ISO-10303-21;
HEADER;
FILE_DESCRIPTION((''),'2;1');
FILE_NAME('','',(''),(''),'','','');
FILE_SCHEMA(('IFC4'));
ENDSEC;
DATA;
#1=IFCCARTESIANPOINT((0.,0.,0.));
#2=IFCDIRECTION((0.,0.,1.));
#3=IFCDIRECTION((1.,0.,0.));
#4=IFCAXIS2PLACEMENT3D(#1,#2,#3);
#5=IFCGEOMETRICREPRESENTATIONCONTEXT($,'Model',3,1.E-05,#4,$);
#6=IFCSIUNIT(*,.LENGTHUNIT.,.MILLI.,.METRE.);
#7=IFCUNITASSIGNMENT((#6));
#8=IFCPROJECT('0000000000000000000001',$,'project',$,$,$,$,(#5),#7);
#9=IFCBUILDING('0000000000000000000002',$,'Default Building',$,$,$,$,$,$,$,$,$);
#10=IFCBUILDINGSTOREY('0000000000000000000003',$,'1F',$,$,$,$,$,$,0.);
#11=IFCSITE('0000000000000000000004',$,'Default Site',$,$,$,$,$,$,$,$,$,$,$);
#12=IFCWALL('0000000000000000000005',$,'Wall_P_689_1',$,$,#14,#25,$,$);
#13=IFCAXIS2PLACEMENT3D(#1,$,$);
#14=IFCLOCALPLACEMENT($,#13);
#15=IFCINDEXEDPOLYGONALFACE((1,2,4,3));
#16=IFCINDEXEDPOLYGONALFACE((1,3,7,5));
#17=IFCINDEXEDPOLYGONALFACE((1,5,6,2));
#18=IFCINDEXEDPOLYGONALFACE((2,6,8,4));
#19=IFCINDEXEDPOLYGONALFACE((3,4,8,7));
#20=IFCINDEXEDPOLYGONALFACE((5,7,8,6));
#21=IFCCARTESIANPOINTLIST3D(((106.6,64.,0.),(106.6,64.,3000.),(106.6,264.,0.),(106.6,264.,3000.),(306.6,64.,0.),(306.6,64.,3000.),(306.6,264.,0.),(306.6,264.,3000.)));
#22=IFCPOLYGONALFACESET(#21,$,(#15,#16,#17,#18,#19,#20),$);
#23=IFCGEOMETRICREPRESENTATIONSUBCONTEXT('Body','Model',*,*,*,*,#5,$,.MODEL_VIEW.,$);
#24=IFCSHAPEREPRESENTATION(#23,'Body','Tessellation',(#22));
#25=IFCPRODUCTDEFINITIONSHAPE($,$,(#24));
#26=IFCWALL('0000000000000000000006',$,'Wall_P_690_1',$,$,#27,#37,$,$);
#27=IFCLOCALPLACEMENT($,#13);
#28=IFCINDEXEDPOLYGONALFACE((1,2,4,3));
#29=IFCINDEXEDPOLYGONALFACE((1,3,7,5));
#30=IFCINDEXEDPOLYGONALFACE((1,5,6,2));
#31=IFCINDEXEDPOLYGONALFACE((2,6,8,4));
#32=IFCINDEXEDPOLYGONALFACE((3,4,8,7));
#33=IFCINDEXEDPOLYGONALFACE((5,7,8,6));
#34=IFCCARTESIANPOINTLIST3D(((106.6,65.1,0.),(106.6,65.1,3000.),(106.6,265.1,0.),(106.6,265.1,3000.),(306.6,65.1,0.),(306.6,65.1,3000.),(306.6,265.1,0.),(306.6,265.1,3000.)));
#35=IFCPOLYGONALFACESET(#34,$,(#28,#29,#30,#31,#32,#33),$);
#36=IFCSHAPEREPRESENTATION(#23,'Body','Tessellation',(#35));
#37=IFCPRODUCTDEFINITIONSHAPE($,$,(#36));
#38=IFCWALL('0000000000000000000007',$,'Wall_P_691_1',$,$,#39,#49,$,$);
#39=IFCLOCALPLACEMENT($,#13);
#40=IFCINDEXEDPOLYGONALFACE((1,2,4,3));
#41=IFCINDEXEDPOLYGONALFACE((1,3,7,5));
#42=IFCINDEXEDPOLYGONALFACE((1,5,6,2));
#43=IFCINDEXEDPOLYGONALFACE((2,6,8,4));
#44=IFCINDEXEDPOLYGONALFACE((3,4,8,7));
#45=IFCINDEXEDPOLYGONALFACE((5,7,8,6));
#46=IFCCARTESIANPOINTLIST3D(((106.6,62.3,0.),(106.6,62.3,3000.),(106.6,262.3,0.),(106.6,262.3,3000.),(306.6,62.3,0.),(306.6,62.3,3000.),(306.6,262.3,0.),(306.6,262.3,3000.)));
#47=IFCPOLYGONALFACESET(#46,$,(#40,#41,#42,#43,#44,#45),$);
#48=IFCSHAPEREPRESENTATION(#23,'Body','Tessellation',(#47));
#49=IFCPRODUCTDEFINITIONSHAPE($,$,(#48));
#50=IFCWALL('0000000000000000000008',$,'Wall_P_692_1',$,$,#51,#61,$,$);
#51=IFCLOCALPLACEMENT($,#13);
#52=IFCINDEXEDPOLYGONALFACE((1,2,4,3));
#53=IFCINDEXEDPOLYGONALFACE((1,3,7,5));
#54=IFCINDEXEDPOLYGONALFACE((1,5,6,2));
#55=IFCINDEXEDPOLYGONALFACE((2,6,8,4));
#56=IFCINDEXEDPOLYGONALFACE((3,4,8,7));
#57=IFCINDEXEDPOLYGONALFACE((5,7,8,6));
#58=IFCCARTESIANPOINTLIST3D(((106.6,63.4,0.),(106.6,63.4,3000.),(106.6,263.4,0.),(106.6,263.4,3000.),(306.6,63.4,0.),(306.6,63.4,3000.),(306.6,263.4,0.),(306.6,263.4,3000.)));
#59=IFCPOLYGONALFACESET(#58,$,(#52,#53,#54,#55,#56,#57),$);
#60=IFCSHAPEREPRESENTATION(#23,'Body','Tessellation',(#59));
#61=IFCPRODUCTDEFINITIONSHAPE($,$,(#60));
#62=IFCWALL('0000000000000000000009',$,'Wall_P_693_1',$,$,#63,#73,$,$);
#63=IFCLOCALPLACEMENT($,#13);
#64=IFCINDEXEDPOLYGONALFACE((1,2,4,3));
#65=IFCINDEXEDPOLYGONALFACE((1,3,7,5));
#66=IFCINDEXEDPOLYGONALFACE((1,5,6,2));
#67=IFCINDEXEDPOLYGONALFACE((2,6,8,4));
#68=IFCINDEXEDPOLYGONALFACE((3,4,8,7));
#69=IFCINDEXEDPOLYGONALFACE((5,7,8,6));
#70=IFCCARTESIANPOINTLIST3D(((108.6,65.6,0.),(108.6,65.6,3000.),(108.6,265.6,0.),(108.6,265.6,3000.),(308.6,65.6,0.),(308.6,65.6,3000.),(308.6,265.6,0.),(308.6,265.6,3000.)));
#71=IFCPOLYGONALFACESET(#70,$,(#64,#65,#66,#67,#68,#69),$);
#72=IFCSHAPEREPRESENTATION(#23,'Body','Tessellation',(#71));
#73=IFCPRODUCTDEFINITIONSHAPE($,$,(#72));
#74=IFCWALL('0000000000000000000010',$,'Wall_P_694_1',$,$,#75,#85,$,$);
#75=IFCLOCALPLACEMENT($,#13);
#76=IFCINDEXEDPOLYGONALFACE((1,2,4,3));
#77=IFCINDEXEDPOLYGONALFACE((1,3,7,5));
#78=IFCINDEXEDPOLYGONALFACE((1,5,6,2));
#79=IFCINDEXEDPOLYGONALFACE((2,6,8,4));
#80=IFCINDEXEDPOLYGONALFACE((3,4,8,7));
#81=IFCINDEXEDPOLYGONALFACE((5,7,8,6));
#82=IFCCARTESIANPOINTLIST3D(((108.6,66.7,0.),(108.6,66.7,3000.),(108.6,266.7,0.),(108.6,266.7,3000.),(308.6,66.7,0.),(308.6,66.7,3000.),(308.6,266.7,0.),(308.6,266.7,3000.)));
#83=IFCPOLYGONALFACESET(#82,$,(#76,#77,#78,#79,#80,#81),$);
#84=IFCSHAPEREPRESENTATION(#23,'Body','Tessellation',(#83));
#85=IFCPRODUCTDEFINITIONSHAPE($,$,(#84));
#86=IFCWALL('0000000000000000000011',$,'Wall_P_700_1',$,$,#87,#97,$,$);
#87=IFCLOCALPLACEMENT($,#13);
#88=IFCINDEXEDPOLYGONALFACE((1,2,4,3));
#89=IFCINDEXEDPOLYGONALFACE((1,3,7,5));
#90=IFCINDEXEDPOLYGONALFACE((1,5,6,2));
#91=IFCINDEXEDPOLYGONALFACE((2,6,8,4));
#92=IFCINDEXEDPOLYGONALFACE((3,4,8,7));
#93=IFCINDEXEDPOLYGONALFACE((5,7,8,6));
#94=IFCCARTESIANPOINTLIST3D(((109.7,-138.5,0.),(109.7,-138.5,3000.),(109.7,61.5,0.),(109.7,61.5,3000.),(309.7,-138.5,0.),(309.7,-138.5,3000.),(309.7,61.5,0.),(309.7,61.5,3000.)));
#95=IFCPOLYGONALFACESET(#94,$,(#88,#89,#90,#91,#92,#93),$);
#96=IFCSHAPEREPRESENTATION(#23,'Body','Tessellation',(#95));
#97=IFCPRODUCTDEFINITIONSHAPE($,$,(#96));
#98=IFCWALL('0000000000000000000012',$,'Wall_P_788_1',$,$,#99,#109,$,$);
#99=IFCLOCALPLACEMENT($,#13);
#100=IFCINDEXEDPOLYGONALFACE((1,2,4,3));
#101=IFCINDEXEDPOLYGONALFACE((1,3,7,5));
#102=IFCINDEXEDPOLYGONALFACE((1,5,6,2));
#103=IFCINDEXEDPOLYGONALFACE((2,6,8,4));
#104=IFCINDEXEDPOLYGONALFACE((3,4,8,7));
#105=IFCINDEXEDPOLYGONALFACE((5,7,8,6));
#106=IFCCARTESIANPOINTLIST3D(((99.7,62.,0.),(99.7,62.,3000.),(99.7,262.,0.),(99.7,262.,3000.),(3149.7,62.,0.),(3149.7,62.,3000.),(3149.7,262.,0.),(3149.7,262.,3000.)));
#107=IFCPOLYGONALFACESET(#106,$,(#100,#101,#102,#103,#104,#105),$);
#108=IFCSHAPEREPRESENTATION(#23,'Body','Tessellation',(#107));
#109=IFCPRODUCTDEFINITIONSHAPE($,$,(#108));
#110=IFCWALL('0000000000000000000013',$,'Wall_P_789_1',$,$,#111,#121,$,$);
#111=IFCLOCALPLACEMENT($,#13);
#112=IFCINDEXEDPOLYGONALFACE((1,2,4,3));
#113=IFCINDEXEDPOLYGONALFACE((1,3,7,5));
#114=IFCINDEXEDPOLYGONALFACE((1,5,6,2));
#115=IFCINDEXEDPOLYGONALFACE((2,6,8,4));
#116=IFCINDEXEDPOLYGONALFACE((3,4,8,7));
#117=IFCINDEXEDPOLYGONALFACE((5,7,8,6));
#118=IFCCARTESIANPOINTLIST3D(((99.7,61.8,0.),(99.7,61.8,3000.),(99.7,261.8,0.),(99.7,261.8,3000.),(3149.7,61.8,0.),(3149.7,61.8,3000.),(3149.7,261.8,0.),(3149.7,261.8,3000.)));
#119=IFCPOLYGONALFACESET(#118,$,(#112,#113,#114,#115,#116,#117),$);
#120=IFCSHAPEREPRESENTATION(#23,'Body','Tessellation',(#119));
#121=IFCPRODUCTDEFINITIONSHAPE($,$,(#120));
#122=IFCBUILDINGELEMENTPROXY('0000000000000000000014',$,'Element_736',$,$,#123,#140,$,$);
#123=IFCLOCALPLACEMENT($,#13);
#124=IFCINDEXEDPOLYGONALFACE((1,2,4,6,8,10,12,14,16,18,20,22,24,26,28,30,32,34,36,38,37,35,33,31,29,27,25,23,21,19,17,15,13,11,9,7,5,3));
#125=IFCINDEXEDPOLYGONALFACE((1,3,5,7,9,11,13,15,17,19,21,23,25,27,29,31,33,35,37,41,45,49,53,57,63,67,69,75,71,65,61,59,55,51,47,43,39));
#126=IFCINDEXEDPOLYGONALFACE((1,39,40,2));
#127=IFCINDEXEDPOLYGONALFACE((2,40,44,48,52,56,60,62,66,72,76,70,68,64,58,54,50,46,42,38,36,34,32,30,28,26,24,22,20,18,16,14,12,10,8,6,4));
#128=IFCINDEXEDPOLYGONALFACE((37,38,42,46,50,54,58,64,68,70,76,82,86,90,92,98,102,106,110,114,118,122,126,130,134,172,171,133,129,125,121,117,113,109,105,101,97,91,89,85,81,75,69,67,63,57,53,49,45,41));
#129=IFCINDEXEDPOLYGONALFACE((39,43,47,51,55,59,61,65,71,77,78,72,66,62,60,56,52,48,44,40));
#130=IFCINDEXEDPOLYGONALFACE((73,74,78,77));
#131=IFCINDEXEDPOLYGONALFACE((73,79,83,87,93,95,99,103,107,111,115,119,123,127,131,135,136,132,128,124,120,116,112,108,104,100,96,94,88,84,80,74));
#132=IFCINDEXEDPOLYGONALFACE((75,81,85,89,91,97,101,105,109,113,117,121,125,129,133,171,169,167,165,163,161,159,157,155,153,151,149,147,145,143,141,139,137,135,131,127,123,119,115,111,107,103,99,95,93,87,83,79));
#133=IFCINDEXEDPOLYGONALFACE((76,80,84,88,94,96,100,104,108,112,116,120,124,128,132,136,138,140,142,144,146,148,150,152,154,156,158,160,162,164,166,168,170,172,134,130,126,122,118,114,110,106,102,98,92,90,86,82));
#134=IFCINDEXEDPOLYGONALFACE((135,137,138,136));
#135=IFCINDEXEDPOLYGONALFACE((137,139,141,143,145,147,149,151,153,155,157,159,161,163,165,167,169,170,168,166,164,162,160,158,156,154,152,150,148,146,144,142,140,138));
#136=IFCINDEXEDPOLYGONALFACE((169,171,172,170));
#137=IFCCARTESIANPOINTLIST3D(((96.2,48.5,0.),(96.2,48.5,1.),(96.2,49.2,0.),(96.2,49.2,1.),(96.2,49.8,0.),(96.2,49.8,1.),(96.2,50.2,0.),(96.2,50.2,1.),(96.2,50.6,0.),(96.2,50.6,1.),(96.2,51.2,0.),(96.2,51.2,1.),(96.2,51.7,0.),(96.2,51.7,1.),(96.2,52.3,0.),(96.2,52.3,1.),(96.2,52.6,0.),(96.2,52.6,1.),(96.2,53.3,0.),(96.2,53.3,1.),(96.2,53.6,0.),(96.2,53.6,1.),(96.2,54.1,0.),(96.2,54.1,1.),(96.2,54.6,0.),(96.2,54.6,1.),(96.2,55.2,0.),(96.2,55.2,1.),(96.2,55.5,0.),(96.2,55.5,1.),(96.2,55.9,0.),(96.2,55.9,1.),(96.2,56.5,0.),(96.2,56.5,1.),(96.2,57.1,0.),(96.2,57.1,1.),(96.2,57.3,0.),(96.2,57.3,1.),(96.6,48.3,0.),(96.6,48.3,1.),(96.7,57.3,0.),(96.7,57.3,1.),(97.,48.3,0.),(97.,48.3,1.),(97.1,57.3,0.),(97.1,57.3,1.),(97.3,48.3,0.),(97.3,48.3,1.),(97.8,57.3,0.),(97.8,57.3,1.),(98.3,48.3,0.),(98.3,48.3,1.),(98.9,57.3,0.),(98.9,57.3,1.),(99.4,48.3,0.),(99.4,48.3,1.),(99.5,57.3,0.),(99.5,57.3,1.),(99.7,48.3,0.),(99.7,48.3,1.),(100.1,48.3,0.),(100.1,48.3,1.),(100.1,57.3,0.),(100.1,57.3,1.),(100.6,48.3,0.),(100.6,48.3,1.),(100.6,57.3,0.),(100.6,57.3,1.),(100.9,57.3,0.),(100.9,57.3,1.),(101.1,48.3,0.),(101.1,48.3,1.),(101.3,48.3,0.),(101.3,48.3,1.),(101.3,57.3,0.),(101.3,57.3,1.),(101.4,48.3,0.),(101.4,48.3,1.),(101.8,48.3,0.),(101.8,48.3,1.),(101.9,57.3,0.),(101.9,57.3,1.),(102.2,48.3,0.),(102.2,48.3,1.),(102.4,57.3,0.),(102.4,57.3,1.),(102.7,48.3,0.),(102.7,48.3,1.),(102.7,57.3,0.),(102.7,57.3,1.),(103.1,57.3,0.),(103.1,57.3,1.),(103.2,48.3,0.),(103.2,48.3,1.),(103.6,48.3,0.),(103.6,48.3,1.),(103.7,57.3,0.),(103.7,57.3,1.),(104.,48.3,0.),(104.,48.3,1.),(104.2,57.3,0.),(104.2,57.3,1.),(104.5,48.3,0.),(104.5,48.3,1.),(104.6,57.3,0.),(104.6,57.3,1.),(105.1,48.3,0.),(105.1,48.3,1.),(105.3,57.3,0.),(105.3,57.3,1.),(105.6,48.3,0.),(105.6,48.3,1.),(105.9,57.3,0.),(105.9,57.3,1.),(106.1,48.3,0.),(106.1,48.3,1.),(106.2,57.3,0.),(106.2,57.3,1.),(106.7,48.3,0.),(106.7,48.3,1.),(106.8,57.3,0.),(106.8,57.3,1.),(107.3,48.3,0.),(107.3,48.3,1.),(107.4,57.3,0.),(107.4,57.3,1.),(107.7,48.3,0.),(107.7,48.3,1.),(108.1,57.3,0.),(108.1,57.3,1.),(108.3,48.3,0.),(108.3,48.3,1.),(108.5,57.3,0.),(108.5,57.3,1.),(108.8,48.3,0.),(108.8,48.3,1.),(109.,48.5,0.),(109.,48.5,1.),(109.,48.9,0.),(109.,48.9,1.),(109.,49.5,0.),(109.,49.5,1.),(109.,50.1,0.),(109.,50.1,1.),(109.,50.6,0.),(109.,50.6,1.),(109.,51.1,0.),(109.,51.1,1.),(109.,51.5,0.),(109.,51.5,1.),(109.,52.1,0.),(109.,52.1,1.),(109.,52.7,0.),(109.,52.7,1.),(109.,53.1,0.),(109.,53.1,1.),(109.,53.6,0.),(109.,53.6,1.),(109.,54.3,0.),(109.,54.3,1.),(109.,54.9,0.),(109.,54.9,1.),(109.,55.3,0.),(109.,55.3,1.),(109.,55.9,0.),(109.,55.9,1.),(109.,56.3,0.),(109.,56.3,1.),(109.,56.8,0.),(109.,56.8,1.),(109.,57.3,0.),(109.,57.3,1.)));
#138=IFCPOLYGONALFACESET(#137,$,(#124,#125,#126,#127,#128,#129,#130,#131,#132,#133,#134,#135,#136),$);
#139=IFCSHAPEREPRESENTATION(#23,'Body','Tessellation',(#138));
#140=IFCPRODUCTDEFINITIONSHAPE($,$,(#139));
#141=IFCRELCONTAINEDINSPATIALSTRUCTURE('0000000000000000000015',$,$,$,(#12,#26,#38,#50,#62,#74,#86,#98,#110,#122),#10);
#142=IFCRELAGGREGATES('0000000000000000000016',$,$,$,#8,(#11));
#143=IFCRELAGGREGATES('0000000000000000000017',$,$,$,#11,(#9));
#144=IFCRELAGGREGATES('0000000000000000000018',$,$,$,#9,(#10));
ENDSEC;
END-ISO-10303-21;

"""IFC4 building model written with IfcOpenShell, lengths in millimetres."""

from ifc_helpers import new_model, si_unit, frame, origin, origin_with_axes, place, context, subcontext, project, spatial, polyline, indexed_curve, outline, extrude, element, save


model = new_model("IFC4")

# Units and contexts
model_context = context("Model", 3, precision=1e-05, world=origin_with_axes())
body_context = subcontext(model_context, "Body", "Model", "MODEL_VIEW")
ifc_project = project(units=[si_unit("LENGTHUNIT", "METRE", prefix="MILLI")], contexts=[model_context])

# Site, building, storey
site = spatial("IfcSite", under=ifc_project, Name="Default Site")
building = spatial("IfcBuilding", under=site, Name="Default Building")
storey = spatial("IfcBuildingStorey", under=building, Name="1F", Elevation=0.0)

# Walls
wall_1_placement = place(None, frame((106.6, 64.0, 0.0), z_axis=(0.0, 0.0, 1.0), x_axis=(1.0, 0.0, 0.0)))
element("IfcWall", 1, at=wall_1_placement, inside=storey, Name="Wall_P_689_1", context=body_context, shape_type="SweptSolid", body=[
    extrude(outline(indexed_curve([(0.0, 0.0), (0.0, 200.0), (200.0, 200.0), (200.0, 0.0), (0.0, 0.0)], self_intersect=False)), origin_with_axes(), (0.0, 0.0, 1.0), 3000.0),
])
wall_2_placement = place(None, frame((106.6, 65.1, 0.0), z_axis=(0.0, 0.0, 1.0), x_axis=(1.0, 0.0, 0.0)))
element("IfcWall", 2, at=wall_2_placement, inside=storey, Name="Wall_P_690_1", context=body_context, shape_type="SweptSolid", body=[
    extrude(outline(indexed_curve([(0.0, 0.0), (0.0, 200.0), (200.0, 200.0), (200.0, 0.0), (0.0, 0.0)], self_intersect=False)), origin_with_axes(), (0.0, 0.0, 1.0), 3000.0),
])
wall_3_placement = place(None, frame((106.6, 62.3, 0.0), z_axis=(0.0, 0.0, 1.0), x_axis=(1.0, 0.0, 0.0)))
element("IfcWall", 3, at=wall_3_placement, inside=storey, Name="Wall_P_691_1", context=body_context, shape_type="SweptSolid", body=[
    extrude(outline(indexed_curve([(0.0, 0.0), (0.0, 200.0), (200.0, 200.0), (200.0, 0.0), (0.0, 0.0)], self_intersect=False)), origin_with_axes(), (0.0, 0.0, 1.0), 3000.0),
])
wall_4_placement = place(None, frame((106.6, 63.4, 0.0), z_axis=(0.0, 0.0, 1.0), x_axis=(1.0, 0.0, 0.0)))
element("IfcWall", 4, at=wall_4_placement, inside=storey, Name="Wall_P_692_1", context=body_context, shape_type="SweptSolid", body=[
    extrude(outline(indexed_curve([(0.0, 0.0), (0.0, 200.0), (200.0, 200.0), (200.0, 0.0), (0.0, 0.0)], self_intersect=False)), origin_with_axes(), (0.0, 0.0, 1.0), 3000.0),
])
wall_5_placement = place(None, frame((108.6, 65.6, 0.0), z_axis=(0.0, 0.0, 1.0), x_axis=(1.0, 0.0, 0.0)))
element("IfcWall", 5, at=wall_5_placement, inside=storey, Name="Wall_P_693_1", context=body_context, shape_type="SweptSolid", body=[
    extrude(outline(indexed_curve([(0.0, 0.0), (0.0, 200.0), (200.0, 200.0), (200.0, 0.0), (0.0, 0.0)], self_intersect=False)), origin_with_axes(), (0.0, 0.0, 1.0), 3000.0),
])
wall_6_placement = place(None, frame((108.6, 66.7, 0.0), z_axis=(0.0, 0.0, 1.0), x_axis=(1.0, 0.0, 0.0)))
element("IfcWall", 6, at=wall_6_placement, inside=storey, Name="Wall_P_694_1", context=body_context, shape_type="SweptSolid", body=[
    extrude(outline(indexed_curve([(0.0, 0.0), (0.0, 200.0), (200.0, 200.0), (200.0, 0.0), (0.0, 0.0)], self_intersect=False)), origin_with_axes(), (0.0, 0.0, 1.0), 3000.0),
])
wall_7_placement = place(None, frame((109.7, 61.5, 0.0), z_axis=(0.0, 0.0, 1.0), x_axis=(0.0, -1.0, 0.0)))
element("IfcWall", 7, at=wall_7_placement, inside=storey, Name="Wall_P_700_1", context=body_context, shape_type="SweptSolid", body=[
    extrude(outline(indexed_curve([(0.0, 0.0), (0.0, 200.0), (200.0, 200.0), (200.0, 0.0), (0.0, 0.0)], self_intersect=False)), origin_with_axes(), (0.0, 0.0, 1.0), 3000.0),
])
for number, where, z_axis, x_axis, name in (
    (8, (99.7, 62.0, 0.0), (0.0, 0.0, 1.0), (1.0, 0.0, 0.0), "Wall_P_788_1"),
    (9, (99.7, 61.8, 0.0), (0.0, 0.0, 1.0), (1.0, 0.0, 0.0), "Wall_P_789_1"),
):
    element("IfcWall", number, at=place(None, frame(where, z_axis=z_axis, x_axis=x_axis)), inside=storey, Name=name, context=body_context, shape_type="SweptSolid", body=[
        extrude(outline(indexed_curve([(0.0, 0.0), (0.0, 200.0), (3050.0, 200.0), (3050.0, 0.0), (0.0, 0.0)], self_intersect=False)), origin_with_axes(), (0.0, 0.0, 1.0), 3000.0),
    ])

# Building element proxy
proxy_1_placement = place(None, frame((102.6, 52.8, 0.0), z_axis=(0.0, 0.0, 1.0), x_axis=(1.0, 0.0, 0.0)))
element("IfcBuildingElementProxy", 10, at=proxy_1_placement, inside=storey, Name="Element_736", context=body_context, shape_type="SweptSolid", body=[
    extrude(outline(polyline([(-6.4, 4.5), (-5.9, 4.5), (-5.5, 4.5), (-4.7, 4.5), (-3.6, 4.5), (-3.1, 4.5), (-2.4, 4.5), (-2.0, 4.5), (-1.6, 4.5), (-1.3, 4.5), (-1.3, 4.5), (-0.7, 4.5), (-0.2, 4.5), (0.1, 4.5), (0.5, 4.5), (1.1, 4.5), (1.7, 4.5), (2.1, 4.5), (2.7, 4.5), (3.3, 4.5), (3.6, 4.5), (4.2, 4.5), (4.9, 4.5), (5.5, 4.5), (5.9, 4.5), (6.4, 4.5), (6.4, 4.0), (6.4, 3.5), (6.4, 3.1), (6.4, 2.5), (6.4, 2.1), (6.4, 1.5), (6.4, 0.8), (6.4, 0.3), (6.4, -0.1), (6.4, -0.7), (6.4, -1.3), (6.4, -1.7), (6.4, -2.2), (6.4, -2.7), (6.4, -3.3), (6.4, -3.9), (6.4, -4.3), (6.2, -4.5), (5.7, -4.5), (5.1, -4.5), (4.8, -4.5), (4.2, -4.5), (3.5, -4.5), (3.0, -4.5), (2.5, -4.5), (2.0, -4.5), (1.4, -4.5), (1.1, -4.5), (0.6, -4.5), (0.1, -4.5), (-0.4, -4.5), (-0.8, -4.5), (-1.3, -4.5), (-1.2, -4.5), (-1.5, -4.5), (-1.9, -4.5), (-2.4, -4.5), (-2.9, -4.5), (-3.2, -4.5), (-4.3, -4.5), (-5.2, -4.5), (-5.6, -4.5), (-6.0, -4.5), (-6.4, -4.3), (-6.4, -3.6), (-6.4, -3.0), (-6.4, -2.6), (-6.4, -2.2), (-6.4, -1.6), (-6.4, -1.1), (-6.4, -0.5), (-6.4, -0.2), (-6.4, 0.5), (-6.4, 0.8), (-6.4, 1.3), (-6.4, 1.8), (-6.4, 2.4), (-6.4, 2.7), (-6.4, 3.1), (-6.4, 3.7), (-6.4, 4.3), (-6.4, 4.5)])), origin(), (0.0, 0.0, 1.0), 1.0),
])

save(model, "model.ifc")
